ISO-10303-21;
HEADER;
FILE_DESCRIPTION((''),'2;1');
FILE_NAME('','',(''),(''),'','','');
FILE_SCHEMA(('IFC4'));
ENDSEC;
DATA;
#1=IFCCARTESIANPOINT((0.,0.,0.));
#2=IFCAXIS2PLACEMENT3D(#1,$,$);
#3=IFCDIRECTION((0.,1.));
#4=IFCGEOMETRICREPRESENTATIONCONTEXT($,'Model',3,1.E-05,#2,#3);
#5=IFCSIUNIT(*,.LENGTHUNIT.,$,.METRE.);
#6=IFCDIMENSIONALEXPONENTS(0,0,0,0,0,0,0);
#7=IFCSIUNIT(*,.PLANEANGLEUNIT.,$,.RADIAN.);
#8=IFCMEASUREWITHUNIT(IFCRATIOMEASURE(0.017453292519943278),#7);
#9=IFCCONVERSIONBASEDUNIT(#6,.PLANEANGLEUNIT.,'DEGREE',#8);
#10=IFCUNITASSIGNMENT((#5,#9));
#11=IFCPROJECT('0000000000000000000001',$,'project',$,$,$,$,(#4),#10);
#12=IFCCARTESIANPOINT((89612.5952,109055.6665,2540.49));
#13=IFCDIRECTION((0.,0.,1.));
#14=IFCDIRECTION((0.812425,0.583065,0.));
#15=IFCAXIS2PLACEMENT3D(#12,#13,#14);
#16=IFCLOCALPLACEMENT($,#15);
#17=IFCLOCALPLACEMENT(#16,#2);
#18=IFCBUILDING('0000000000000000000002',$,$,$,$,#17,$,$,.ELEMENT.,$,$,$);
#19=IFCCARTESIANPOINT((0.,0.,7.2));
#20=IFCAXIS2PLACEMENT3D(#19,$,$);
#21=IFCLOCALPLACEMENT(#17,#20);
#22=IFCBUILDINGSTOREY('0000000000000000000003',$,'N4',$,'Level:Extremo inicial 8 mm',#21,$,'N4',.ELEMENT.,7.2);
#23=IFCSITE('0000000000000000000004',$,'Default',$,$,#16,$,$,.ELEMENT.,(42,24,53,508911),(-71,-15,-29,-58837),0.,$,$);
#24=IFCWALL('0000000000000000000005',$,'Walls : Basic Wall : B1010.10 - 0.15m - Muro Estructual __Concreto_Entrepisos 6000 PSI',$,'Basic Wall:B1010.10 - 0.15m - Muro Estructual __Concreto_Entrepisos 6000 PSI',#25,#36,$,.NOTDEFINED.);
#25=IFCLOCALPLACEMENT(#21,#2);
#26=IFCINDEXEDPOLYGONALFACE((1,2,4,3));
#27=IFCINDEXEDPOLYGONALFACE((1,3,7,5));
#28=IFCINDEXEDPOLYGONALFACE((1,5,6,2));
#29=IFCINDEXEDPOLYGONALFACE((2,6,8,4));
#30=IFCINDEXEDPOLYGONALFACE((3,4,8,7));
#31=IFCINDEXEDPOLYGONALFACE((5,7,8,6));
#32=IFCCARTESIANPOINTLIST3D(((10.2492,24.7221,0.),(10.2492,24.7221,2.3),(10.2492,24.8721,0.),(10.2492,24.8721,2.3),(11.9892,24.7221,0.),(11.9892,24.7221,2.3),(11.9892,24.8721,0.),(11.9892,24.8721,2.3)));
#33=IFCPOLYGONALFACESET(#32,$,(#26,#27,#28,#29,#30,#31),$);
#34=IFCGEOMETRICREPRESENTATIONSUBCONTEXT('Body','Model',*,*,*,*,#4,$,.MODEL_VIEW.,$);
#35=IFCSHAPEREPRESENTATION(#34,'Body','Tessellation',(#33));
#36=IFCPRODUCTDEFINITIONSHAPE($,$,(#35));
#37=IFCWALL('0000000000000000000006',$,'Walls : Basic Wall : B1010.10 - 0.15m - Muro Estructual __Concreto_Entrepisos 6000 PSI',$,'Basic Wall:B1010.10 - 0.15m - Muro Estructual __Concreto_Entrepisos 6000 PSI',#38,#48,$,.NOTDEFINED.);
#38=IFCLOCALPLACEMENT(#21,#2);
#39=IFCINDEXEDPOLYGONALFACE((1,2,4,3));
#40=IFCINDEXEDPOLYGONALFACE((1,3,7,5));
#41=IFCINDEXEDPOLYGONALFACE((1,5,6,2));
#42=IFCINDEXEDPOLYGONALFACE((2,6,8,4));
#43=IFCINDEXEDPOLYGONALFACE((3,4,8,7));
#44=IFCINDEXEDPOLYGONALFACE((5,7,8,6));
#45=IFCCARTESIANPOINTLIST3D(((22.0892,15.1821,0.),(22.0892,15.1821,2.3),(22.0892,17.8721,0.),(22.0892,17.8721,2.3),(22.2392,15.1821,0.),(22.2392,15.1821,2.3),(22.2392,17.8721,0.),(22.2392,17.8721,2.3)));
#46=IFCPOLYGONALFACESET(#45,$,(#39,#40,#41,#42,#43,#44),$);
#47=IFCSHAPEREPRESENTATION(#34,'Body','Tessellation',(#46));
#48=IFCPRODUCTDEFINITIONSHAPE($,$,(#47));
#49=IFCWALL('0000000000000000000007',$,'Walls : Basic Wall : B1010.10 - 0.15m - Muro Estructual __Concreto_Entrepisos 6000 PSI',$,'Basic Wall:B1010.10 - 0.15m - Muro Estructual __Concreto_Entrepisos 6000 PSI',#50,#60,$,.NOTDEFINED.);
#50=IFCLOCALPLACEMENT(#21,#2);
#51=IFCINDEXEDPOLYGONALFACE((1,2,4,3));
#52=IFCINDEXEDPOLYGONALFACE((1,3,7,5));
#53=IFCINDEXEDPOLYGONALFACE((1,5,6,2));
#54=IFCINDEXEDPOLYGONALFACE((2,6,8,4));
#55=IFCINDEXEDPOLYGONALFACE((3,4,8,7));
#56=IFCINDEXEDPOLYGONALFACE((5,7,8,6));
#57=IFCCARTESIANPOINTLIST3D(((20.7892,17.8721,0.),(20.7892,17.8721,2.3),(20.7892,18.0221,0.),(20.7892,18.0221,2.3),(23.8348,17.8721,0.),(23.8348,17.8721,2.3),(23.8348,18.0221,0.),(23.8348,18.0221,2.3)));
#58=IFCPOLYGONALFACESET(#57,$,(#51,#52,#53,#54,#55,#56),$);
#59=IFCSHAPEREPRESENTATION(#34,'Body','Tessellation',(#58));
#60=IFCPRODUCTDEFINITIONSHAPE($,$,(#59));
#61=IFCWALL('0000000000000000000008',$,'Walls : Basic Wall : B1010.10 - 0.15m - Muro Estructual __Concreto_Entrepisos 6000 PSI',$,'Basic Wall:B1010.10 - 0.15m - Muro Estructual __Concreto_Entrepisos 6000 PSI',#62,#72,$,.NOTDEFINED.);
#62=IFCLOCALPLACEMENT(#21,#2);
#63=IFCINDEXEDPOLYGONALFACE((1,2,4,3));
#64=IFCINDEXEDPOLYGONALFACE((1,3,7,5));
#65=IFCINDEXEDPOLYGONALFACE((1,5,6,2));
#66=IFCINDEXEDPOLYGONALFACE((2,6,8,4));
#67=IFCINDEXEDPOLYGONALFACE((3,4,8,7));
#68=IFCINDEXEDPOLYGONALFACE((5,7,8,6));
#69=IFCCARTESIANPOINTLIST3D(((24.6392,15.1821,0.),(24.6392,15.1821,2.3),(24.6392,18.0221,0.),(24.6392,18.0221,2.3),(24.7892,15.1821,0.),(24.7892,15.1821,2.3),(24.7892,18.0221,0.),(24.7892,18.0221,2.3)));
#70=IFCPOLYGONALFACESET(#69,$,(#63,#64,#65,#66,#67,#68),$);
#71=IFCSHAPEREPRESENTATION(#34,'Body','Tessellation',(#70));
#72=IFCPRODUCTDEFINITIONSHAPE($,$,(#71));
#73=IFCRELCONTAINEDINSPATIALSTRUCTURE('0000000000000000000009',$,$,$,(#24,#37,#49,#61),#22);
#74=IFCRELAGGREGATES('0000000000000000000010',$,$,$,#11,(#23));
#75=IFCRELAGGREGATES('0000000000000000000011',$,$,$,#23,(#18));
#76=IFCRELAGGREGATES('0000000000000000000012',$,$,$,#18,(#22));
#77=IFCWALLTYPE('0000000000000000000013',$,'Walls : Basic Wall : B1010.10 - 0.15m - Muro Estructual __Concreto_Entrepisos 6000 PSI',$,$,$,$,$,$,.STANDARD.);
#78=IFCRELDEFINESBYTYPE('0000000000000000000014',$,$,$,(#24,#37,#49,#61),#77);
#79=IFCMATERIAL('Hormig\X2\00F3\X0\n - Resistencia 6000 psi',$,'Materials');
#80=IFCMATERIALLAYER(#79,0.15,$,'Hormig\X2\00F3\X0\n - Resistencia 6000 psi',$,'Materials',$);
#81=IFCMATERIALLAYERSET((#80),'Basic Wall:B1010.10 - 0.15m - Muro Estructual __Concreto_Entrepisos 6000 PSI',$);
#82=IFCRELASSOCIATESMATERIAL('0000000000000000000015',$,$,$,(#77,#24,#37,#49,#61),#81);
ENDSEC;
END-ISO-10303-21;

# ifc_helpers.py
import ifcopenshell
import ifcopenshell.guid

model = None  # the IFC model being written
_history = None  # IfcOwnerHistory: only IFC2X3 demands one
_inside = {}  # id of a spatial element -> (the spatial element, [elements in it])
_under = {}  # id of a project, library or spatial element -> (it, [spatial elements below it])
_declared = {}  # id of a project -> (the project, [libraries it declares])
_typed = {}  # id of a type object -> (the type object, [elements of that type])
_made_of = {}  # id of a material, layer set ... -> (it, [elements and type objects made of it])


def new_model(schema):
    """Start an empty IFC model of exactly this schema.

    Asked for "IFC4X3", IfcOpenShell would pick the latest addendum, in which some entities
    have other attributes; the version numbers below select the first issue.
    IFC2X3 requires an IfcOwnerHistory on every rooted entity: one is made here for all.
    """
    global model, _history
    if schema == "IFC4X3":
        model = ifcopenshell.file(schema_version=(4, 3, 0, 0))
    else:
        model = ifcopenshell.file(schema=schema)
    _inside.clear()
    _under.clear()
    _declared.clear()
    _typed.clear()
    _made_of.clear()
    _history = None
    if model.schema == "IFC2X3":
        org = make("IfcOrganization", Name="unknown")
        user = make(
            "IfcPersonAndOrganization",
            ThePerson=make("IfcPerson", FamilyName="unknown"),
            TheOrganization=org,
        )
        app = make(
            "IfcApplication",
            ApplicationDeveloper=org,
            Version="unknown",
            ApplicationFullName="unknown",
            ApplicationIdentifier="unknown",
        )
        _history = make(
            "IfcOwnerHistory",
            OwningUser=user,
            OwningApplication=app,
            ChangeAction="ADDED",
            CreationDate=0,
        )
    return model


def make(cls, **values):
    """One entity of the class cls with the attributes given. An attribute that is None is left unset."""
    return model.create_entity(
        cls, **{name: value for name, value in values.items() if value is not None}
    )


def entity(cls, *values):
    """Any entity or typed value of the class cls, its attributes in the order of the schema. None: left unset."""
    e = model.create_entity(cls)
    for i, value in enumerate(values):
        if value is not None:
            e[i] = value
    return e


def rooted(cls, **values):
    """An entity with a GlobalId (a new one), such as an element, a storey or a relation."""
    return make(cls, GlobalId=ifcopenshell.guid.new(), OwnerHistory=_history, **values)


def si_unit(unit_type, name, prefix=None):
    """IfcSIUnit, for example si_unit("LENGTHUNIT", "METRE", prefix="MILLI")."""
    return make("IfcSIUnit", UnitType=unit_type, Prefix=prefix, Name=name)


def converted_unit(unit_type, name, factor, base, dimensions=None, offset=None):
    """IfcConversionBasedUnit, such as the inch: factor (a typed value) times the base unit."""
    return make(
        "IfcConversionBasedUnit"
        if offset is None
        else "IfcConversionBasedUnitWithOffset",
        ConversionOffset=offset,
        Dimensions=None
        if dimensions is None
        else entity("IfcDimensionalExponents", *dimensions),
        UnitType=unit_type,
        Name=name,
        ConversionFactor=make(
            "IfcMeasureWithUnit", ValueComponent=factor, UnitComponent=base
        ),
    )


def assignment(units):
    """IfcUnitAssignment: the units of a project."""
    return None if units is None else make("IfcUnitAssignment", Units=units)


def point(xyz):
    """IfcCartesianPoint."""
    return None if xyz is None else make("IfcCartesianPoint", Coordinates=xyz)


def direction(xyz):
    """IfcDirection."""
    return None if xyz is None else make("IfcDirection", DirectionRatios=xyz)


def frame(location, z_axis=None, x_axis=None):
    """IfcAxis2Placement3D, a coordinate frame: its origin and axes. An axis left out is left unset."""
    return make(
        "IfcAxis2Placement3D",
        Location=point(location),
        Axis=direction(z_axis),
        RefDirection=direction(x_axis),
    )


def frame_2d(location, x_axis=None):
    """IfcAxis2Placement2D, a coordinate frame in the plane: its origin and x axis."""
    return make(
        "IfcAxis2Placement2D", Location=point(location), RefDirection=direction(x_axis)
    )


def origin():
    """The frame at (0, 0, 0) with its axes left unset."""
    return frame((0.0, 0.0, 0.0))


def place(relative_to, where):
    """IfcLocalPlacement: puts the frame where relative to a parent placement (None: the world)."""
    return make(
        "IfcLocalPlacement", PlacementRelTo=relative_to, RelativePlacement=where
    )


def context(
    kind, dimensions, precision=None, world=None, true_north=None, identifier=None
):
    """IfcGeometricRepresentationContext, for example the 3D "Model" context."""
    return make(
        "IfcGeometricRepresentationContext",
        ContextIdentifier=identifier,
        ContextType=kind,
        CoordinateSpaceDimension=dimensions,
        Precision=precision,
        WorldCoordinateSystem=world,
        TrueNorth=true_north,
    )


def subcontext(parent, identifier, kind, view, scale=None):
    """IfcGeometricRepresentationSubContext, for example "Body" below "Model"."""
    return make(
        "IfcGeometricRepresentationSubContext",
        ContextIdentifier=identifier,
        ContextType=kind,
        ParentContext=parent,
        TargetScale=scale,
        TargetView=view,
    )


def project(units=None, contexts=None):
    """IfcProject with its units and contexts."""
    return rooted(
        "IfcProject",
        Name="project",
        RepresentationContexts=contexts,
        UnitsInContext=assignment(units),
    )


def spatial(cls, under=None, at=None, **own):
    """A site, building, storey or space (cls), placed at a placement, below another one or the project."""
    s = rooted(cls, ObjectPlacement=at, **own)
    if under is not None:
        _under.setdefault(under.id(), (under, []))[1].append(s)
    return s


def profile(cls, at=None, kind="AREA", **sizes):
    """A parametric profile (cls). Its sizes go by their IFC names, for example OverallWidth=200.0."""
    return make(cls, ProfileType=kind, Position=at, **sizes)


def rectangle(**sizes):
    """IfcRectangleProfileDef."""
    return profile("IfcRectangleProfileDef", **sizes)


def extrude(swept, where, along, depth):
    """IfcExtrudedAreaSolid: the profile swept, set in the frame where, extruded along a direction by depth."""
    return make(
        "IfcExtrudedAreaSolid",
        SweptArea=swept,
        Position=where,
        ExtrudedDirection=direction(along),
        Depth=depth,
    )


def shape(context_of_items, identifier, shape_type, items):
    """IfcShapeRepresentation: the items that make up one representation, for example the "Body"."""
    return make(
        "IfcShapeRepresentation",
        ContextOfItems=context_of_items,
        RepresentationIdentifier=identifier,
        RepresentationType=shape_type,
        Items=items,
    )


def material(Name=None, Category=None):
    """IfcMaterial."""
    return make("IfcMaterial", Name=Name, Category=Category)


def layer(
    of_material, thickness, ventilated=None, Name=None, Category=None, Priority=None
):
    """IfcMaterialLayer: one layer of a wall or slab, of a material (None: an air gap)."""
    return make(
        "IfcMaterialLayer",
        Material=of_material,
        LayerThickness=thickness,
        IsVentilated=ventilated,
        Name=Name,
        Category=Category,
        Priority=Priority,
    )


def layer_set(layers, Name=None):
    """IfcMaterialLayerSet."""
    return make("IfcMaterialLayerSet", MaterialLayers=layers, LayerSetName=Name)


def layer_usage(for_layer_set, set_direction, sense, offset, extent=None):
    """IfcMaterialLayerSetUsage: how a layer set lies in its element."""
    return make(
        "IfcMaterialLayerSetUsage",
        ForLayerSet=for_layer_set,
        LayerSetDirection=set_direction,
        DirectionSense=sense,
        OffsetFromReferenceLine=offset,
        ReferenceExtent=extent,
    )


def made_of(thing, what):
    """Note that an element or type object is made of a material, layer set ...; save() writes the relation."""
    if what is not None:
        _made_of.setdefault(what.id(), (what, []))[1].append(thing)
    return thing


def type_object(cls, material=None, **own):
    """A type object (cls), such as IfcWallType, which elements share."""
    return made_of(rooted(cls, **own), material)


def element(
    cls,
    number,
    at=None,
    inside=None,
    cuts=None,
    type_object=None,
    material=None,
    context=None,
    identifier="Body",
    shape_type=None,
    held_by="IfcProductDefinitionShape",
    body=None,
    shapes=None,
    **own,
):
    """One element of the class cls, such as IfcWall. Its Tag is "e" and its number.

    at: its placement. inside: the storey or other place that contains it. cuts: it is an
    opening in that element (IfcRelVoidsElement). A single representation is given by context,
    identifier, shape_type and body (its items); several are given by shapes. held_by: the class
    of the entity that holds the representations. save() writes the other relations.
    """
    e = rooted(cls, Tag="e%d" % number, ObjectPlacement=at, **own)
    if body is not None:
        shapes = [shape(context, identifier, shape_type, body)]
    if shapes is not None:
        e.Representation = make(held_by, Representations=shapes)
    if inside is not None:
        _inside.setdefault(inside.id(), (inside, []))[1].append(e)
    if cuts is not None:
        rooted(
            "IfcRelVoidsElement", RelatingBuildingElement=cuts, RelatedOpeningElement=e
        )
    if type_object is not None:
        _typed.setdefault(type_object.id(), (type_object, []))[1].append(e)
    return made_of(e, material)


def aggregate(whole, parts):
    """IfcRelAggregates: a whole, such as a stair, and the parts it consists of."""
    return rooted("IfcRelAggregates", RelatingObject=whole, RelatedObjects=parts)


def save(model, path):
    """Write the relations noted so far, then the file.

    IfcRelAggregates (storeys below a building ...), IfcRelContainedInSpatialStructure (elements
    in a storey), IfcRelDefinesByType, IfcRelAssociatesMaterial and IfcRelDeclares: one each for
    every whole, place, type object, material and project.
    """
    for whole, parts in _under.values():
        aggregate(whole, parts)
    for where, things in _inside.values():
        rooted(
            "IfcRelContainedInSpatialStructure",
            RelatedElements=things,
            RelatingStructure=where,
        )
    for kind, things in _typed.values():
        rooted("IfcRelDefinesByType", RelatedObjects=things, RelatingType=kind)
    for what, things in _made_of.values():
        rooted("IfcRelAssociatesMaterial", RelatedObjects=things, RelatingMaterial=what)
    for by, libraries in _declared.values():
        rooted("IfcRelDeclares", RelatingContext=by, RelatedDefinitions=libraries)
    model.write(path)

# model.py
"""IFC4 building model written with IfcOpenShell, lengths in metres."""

from ifc_helpers import new_model, entity, si_unit, converted_unit, direction, frame, frame_2d, origin, place, context, subcontext, project, spatial, rectangle, extrude, material, layer, layer_set, layer_usage, type_object, element, save


model = new_model("IFC4")

# Units and contexts
model_context = context("Model", 3, precision=1e-05, world=origin(), true_north=direction((0.0, 1.0)))
body_context = subcontext(model_context, "Body", "Model", "MODEL_VIEW")
ifc_project = project(units=[si_unit("LENGTHUNIT", "METRE"), converted_unit("PLANEANGLEUNIT", "DEGREE", entity("IfcRatioMeasure", 0.017453292519943278), si_unit("PLANEANGLEUNIT", "RADIAN"), dimensions=[0, 0, 0, 0, 0, 0, 0])], contexts=[model_context])

# Site, building, storey
site_placement = place(None, frame((89612.5952, 109055.6665, 2540.49), z_axis=(0.0, 0.0, 1.0), x_axis=(0.812425, 0.583065, 0.0)))
site = spatial("IfcSite", under=ifc_project, at=site_placement, Name="Default", CompositionType="ELEMENT", RefLatitude=(42, 24, 53, 508911), RefLongitude=(-71, -15, -29, -58837), RefElevation=0.0)
building_placement = place(site_placement, origin())
building = spatial("IfcBuilding", under=site, at=building_placement, CompositionType="ELEMENT")
storey_placement = place(building_placement, frame((0.0, 0.0, 7.2)))
storey = spatial("IfcBuildingStorey", under=building, at=storey_placement, Name="N4", ObjectType="Level:Extremo inicial 8 mm", LongName="N4", CompositionType="ELEMENT", Elevation=7.2)

# Walls
ifc_material = material(Name="Hormigón - Resistencia 6000 psi", Category="Materials")
ifc_layer_1 = layer(ifc_material, 0.15, Name="Hormigón - Resistencia 6000 psi", Category="Materials")
ifc_layer_set_1 = layer_set([ifc_layer_1], Name="Basic Wall:B1010.10 - 0.15m - Muro Estructual __Concreto_Entrepisos 6000 PSI")
wall_type_1 = type_object("IfcWallType", Name="Walls : Basic Wall : B1010.10 - 0.15m - Muro Estructual __Concreto_Entrepisos 6000 PSI", PredefinedType="STANDARD", material=ifc_layer_set_1)
ifc_layer_usage_1 = layer_usage(ifc_layer_set_1, "AXIS2", "POSITIVE", -0.075)
wall_1_placement = place(storey_placement, frame((11.9892, 24.7971, 0.0), z_axis=(0.0, 0.0, 1.0), x_axis=(-1.0, 0.0, 0.0)))
element("IfcWall", 1, at=wall_1_placement, inside=storey, type_object=wall_type_1, material=ifc_layer_usage_1, Name="Walls : Basic Wall : B1010.10 - 0.15m - Muro Estructual __Concreto_Entrepisos 6000 PSI", ObjectType="Basic Wall:B1010.10 - 0.15m - Muro Estructual __Concreto_Entrepisos 6000 PSI", PredefinedType="NOTDEFINED", context=body_context, shape_type="SweptSolid", body=[
    extrude(rectangle(XDim=1.74, YDim=0.15, at=frame_2d((0.87, 0.0), x_axis=(-1.0, 0.0))), origin(), (0.0, 0.0, 1.0), 2.3),
])
ifc_layer_usage_2 = layer_usage(ifc_layer_set_1, "AXIS2", "POSITIVE", -0.075)
wall_2_placement = place(storey_placement, frame((22.1642, 15.1821, 0.0), z_axis=(0.0, 0.0, 1.0), x_axis=(0.0, 1.0, 0.0)))
element("IfcWall", 2, at=wall_2_placement, inside=storey, type_object=wall_type_1, material=ifc_layer_usage_2, Name="Walls : Basic Wall : B1010.10 - 0.15m - Muro Estructual __Concreto_Entrepisos 6000 PSI", ObjectType="Basic Wall:B1010.10 - 0.15m - Muro Estructual __Concreto_Entrepisos 6000 PSI", PredefinedType="NOTDEFINED", context=body_context, shape_type="SweptSolid", body=[
    extrude(rectangle(XDim=2.69, YDim=0.15, at=frame_2d((1.345, 0.0), x_axis=(-1.0, 0.0))), origin(), (0.0, 0.0, 1.0), 2.3),
])
ifc_layer_usage_3 = layer_usage(ifc_layer_set_1, "AXIS2", "POSITIVE", -0.075)
wall_3_placement = place(storey_placement, frame((20.7892, 17.9471, 0.0)))
element("IfcWall", 3, at=wall_3_placement, inside=storey, type_object=wall_type_1, material=ifc_layer_usage_3, Name="Walls : Basic Wall : B1010.10 - 0.15m - Muro Estructual __Concreto_Entrepisos 6000 PSI", ObjectType="Basic Wall:B1010.10 - 0.15m - Muro Estructual __Concreto_Entrepisos 6000 PSI", PredefinedType="NOTDEFINED", context=body_context, shape_type="SweptSolid", body=[
    extrude(rectangle(XDim=3.0455, YDim=0.15, at=frame_2d((1.5228, 0.0), x_axis=(-1.0, 0.0))), origin(), (0.0, 0.0, 1.0), 2.3),
])
ifc_layer_usage_4 = layer_usage(ifc_layer_set_1, "AXIS2", "POSITIVE", -0.075)
wall_4_placement = place(storey_placement, frame((24.7142, 15.1821, 0.0), z_axis=(0.0, 0.0, 1.0), x_axis=(0.0, 1.0, 0.0)))
element("IfcWall", 4, at=wall_4_placement, inside=storey, type_object=wall_type_1, material=ifc_layer_usage_4, Name="Walls : Basic Wall : B1010.10 - 0.15m - Muro Estructual __Concreto_Entrepisos 6000 PSI", ObjectType="Basic Wall:B1010.10 - 0.15m - Muro Estructual __Concreto_Entrepisos 6000 PSI", PredefinedType="NOTDEFINED", context=body_context, shape_type="SweptSolid", body=[
    extrude(rectangle(XDim=2.84, YDim=0.15, at=frame_2d((1.42, 0.0), x_axis=(-1.0, 0.0))), origin(), (0.0, 0.0, 1.0), 2.3),
])

save(model, "model.ifc")
